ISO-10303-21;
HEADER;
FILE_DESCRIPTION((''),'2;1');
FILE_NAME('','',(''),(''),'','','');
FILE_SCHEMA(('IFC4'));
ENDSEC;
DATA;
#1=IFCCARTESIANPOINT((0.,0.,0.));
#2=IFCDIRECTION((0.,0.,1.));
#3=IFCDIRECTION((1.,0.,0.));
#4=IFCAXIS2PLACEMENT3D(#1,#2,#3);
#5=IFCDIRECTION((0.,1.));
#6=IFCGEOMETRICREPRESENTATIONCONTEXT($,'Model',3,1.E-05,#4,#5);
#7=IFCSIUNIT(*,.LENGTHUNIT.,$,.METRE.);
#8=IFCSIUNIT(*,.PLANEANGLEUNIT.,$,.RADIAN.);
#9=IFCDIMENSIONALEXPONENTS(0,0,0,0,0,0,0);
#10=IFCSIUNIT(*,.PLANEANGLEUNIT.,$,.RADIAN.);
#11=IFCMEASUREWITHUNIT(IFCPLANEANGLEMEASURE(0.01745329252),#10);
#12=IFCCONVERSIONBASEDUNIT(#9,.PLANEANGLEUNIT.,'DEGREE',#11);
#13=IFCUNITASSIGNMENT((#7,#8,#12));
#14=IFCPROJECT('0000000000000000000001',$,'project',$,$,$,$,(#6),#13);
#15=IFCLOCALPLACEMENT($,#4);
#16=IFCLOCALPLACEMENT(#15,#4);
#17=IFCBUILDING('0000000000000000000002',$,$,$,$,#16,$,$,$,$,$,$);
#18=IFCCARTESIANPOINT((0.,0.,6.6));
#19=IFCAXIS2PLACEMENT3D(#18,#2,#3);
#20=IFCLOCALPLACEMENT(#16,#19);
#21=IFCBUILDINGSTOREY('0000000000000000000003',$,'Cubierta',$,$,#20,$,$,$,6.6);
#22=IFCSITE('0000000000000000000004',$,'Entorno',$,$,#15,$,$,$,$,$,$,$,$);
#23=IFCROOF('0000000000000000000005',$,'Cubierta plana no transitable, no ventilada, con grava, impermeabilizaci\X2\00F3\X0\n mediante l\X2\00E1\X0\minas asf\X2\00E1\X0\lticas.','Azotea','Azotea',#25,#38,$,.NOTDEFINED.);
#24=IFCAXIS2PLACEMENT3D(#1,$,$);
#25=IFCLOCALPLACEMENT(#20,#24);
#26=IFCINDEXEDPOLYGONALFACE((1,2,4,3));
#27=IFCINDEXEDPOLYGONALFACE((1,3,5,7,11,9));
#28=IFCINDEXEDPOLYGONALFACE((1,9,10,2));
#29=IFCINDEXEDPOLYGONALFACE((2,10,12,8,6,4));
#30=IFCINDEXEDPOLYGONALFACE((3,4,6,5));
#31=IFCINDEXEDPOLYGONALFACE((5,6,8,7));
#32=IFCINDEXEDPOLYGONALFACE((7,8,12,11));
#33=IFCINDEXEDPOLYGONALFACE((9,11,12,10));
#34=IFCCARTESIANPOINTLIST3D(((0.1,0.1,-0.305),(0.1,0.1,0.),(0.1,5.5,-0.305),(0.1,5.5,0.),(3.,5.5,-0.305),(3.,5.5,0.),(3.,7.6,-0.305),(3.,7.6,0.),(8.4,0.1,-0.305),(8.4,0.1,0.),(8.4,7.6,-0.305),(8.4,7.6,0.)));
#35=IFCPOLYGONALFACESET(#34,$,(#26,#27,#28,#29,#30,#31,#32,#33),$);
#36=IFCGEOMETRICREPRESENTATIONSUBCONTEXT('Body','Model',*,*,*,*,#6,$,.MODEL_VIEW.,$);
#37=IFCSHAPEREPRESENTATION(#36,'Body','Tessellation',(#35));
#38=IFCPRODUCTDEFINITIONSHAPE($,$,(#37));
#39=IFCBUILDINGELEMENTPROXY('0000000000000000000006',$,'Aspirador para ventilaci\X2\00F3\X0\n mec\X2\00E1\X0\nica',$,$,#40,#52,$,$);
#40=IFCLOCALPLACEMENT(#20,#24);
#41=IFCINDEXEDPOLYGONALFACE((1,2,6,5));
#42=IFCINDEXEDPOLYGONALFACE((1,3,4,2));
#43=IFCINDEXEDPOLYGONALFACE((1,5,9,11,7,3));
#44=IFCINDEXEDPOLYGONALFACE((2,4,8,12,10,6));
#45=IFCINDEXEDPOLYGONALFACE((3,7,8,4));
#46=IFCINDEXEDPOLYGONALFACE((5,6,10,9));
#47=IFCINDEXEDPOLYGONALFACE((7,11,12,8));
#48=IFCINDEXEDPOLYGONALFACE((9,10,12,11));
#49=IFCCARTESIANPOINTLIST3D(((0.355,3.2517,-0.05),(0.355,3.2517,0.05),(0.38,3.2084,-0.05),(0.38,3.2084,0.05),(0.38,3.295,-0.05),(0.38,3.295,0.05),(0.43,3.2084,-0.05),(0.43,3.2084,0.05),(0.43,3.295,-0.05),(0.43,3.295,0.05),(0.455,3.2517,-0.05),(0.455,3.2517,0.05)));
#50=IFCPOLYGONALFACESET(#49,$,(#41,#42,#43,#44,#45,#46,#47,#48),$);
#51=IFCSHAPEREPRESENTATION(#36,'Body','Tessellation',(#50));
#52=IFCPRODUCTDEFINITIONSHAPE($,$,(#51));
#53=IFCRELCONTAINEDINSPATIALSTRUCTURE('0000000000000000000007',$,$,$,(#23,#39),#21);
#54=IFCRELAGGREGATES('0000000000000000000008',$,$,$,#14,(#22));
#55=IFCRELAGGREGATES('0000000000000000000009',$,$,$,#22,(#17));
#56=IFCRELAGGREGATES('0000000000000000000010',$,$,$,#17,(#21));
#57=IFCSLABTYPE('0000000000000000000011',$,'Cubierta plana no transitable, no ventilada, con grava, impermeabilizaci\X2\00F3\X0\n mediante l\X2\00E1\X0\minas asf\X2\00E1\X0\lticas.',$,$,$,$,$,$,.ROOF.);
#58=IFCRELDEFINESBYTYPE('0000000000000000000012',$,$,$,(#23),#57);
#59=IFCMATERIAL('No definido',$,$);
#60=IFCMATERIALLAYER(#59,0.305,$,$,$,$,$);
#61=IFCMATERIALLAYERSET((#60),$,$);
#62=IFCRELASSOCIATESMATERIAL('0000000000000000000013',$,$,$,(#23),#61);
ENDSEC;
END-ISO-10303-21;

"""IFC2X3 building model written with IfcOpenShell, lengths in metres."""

from ifc_helpers import new_model, entity, si_unit, converted_unit, direction, frame, origin_with_axes, place, context, subcontext, project, spatial, polyline, outline, extrude, source, transform, mapped, material, layer, layer_set, layer_usage, type_object, element, save


model = new_model("IFC2X3")

# Units and contexts
model_context = context("Model", 3, precision=1e-05, world=origin_with_axes(), true_north=direction((0.0, 1.0)))
body_context = subcontext(model_context, "Body", "Model", "MODEL_VIEW")
ifc_project = project(units=[si_unit("LENGTHUNIT", "METRE"), si_unit("PLANEANGLEUNIT", "RADIAN"), converted_unit("PLANEANGLEUNIT", "DEGREE", entity("IfcPlaneAngleMeasure", 0.01745329252), si_unit("PLANEANGLEUNIT", "RADIAN"), dimensions=[0, 0, 0, 0, 0, 0, 0])], contexts=[model_context])

# Site, building, storey
site_placement = place(None, origin_with_axes())
site = spatial("IfcSite", under=ifc_project, at=site_placement, Name="Entorno")
building_placement = place(site_placement, origin_with_axes())
building = spatial("IfcBuilding", under=site, at=building_placement)
storey_placement = place(building_placement, frame((0.0, 0.0, 6.6), z_axis=(0.0, 0.0, 1.0), x_axis=(1.0, 0.0, 0.0)))
storey = spatial("IfcBuildingStorey", under=building, at=storey_placement, Name="Cubierta", Elevation=6.6)

# Roof
ifc_material = material(Name="No definido")
ifc_layer = layer(ifc_material, 0.305)
ifc_layer_set = layer_set([ifc_layer])
ifc_layer_usage = layer_usage(ifc_layer_set, "AXIS3", "POSITIVE", 0.0)
slab_type = type_object("IfcSlabType", Name="Cubierta plana no transitable, no ventilada, con grava, impermeabilización mediante láminas asfálticas.", PredefinedType="ROOF")
roof_placement = place(storey_placement, frame((3.0, 7.6, -0.305), z_axis=(0.0, 0.0, 1.0), x_axis=(1.0, 0.0, 0.0)))
element("IfcRoof", 1, at=roof_placement, inside=storey, type_object=slab_type, material=ifc_layer_usage, Name="Cubierta plana no transitable, no ventilada, con grava, impermeabilización mediante láminas asfálticas.", Description="Azotea", ObjectType="Azotea", ShapeType="NOTDEFINED", context=body_context, shape_type="SweptSolid", body=[
    extrude(outline(polyline([(0.0, 0.0), (0.0, -2.1), (-2.9, -2.1), (-2.9, -7.5), (5.4, -7.5), (5.4, 0.0), (0.0, 0.0)])), origin_with_axes(), (0.0, 0.0, 1.0), 0.305),
])

# Building element proxy
shared_shape = source(origin_with_axes(), body_context, "Body", "SolidModel", [
    extrude(outline(polyline([(0.05, 0.0), (0.025, 0.0433), (-0.025, 0.0433), (-0.05, 0.0), (-0.025, -0.0433), (0.025, -0.0433), (0.05, 0.0)])), frame((0.0, 0.0, -0.05), z_axis=(0.0, 0.0, 1.0), x_axis=(1.0, 0.0, 0.0)), (0.0, 0.0, 1.0), 0.1),
])
proxy_1_placement = place(storey_placement, frame((0.0, 0.0, -6.6), z_axis=(0.0, 0.0, 1.0), x_axis=(1.0, 0.0, 0.0)))
element("IfcBuildingElementProxy", 2, at=proxy_1_placement, inside=storey, Name="Aspirador para ventilación mecánica", context=body_context, shape_type="Brep", body=[
    mapped(shared_shape, transform((0.405, 3.2517, 6.6), x_axis=(-1.0, 0.0, 0.0), y_axis=(0.0, -1.0, 0.0), z_axis=(0.0, 0.0, 1.0))),
])

save(model, "model.ifc")
